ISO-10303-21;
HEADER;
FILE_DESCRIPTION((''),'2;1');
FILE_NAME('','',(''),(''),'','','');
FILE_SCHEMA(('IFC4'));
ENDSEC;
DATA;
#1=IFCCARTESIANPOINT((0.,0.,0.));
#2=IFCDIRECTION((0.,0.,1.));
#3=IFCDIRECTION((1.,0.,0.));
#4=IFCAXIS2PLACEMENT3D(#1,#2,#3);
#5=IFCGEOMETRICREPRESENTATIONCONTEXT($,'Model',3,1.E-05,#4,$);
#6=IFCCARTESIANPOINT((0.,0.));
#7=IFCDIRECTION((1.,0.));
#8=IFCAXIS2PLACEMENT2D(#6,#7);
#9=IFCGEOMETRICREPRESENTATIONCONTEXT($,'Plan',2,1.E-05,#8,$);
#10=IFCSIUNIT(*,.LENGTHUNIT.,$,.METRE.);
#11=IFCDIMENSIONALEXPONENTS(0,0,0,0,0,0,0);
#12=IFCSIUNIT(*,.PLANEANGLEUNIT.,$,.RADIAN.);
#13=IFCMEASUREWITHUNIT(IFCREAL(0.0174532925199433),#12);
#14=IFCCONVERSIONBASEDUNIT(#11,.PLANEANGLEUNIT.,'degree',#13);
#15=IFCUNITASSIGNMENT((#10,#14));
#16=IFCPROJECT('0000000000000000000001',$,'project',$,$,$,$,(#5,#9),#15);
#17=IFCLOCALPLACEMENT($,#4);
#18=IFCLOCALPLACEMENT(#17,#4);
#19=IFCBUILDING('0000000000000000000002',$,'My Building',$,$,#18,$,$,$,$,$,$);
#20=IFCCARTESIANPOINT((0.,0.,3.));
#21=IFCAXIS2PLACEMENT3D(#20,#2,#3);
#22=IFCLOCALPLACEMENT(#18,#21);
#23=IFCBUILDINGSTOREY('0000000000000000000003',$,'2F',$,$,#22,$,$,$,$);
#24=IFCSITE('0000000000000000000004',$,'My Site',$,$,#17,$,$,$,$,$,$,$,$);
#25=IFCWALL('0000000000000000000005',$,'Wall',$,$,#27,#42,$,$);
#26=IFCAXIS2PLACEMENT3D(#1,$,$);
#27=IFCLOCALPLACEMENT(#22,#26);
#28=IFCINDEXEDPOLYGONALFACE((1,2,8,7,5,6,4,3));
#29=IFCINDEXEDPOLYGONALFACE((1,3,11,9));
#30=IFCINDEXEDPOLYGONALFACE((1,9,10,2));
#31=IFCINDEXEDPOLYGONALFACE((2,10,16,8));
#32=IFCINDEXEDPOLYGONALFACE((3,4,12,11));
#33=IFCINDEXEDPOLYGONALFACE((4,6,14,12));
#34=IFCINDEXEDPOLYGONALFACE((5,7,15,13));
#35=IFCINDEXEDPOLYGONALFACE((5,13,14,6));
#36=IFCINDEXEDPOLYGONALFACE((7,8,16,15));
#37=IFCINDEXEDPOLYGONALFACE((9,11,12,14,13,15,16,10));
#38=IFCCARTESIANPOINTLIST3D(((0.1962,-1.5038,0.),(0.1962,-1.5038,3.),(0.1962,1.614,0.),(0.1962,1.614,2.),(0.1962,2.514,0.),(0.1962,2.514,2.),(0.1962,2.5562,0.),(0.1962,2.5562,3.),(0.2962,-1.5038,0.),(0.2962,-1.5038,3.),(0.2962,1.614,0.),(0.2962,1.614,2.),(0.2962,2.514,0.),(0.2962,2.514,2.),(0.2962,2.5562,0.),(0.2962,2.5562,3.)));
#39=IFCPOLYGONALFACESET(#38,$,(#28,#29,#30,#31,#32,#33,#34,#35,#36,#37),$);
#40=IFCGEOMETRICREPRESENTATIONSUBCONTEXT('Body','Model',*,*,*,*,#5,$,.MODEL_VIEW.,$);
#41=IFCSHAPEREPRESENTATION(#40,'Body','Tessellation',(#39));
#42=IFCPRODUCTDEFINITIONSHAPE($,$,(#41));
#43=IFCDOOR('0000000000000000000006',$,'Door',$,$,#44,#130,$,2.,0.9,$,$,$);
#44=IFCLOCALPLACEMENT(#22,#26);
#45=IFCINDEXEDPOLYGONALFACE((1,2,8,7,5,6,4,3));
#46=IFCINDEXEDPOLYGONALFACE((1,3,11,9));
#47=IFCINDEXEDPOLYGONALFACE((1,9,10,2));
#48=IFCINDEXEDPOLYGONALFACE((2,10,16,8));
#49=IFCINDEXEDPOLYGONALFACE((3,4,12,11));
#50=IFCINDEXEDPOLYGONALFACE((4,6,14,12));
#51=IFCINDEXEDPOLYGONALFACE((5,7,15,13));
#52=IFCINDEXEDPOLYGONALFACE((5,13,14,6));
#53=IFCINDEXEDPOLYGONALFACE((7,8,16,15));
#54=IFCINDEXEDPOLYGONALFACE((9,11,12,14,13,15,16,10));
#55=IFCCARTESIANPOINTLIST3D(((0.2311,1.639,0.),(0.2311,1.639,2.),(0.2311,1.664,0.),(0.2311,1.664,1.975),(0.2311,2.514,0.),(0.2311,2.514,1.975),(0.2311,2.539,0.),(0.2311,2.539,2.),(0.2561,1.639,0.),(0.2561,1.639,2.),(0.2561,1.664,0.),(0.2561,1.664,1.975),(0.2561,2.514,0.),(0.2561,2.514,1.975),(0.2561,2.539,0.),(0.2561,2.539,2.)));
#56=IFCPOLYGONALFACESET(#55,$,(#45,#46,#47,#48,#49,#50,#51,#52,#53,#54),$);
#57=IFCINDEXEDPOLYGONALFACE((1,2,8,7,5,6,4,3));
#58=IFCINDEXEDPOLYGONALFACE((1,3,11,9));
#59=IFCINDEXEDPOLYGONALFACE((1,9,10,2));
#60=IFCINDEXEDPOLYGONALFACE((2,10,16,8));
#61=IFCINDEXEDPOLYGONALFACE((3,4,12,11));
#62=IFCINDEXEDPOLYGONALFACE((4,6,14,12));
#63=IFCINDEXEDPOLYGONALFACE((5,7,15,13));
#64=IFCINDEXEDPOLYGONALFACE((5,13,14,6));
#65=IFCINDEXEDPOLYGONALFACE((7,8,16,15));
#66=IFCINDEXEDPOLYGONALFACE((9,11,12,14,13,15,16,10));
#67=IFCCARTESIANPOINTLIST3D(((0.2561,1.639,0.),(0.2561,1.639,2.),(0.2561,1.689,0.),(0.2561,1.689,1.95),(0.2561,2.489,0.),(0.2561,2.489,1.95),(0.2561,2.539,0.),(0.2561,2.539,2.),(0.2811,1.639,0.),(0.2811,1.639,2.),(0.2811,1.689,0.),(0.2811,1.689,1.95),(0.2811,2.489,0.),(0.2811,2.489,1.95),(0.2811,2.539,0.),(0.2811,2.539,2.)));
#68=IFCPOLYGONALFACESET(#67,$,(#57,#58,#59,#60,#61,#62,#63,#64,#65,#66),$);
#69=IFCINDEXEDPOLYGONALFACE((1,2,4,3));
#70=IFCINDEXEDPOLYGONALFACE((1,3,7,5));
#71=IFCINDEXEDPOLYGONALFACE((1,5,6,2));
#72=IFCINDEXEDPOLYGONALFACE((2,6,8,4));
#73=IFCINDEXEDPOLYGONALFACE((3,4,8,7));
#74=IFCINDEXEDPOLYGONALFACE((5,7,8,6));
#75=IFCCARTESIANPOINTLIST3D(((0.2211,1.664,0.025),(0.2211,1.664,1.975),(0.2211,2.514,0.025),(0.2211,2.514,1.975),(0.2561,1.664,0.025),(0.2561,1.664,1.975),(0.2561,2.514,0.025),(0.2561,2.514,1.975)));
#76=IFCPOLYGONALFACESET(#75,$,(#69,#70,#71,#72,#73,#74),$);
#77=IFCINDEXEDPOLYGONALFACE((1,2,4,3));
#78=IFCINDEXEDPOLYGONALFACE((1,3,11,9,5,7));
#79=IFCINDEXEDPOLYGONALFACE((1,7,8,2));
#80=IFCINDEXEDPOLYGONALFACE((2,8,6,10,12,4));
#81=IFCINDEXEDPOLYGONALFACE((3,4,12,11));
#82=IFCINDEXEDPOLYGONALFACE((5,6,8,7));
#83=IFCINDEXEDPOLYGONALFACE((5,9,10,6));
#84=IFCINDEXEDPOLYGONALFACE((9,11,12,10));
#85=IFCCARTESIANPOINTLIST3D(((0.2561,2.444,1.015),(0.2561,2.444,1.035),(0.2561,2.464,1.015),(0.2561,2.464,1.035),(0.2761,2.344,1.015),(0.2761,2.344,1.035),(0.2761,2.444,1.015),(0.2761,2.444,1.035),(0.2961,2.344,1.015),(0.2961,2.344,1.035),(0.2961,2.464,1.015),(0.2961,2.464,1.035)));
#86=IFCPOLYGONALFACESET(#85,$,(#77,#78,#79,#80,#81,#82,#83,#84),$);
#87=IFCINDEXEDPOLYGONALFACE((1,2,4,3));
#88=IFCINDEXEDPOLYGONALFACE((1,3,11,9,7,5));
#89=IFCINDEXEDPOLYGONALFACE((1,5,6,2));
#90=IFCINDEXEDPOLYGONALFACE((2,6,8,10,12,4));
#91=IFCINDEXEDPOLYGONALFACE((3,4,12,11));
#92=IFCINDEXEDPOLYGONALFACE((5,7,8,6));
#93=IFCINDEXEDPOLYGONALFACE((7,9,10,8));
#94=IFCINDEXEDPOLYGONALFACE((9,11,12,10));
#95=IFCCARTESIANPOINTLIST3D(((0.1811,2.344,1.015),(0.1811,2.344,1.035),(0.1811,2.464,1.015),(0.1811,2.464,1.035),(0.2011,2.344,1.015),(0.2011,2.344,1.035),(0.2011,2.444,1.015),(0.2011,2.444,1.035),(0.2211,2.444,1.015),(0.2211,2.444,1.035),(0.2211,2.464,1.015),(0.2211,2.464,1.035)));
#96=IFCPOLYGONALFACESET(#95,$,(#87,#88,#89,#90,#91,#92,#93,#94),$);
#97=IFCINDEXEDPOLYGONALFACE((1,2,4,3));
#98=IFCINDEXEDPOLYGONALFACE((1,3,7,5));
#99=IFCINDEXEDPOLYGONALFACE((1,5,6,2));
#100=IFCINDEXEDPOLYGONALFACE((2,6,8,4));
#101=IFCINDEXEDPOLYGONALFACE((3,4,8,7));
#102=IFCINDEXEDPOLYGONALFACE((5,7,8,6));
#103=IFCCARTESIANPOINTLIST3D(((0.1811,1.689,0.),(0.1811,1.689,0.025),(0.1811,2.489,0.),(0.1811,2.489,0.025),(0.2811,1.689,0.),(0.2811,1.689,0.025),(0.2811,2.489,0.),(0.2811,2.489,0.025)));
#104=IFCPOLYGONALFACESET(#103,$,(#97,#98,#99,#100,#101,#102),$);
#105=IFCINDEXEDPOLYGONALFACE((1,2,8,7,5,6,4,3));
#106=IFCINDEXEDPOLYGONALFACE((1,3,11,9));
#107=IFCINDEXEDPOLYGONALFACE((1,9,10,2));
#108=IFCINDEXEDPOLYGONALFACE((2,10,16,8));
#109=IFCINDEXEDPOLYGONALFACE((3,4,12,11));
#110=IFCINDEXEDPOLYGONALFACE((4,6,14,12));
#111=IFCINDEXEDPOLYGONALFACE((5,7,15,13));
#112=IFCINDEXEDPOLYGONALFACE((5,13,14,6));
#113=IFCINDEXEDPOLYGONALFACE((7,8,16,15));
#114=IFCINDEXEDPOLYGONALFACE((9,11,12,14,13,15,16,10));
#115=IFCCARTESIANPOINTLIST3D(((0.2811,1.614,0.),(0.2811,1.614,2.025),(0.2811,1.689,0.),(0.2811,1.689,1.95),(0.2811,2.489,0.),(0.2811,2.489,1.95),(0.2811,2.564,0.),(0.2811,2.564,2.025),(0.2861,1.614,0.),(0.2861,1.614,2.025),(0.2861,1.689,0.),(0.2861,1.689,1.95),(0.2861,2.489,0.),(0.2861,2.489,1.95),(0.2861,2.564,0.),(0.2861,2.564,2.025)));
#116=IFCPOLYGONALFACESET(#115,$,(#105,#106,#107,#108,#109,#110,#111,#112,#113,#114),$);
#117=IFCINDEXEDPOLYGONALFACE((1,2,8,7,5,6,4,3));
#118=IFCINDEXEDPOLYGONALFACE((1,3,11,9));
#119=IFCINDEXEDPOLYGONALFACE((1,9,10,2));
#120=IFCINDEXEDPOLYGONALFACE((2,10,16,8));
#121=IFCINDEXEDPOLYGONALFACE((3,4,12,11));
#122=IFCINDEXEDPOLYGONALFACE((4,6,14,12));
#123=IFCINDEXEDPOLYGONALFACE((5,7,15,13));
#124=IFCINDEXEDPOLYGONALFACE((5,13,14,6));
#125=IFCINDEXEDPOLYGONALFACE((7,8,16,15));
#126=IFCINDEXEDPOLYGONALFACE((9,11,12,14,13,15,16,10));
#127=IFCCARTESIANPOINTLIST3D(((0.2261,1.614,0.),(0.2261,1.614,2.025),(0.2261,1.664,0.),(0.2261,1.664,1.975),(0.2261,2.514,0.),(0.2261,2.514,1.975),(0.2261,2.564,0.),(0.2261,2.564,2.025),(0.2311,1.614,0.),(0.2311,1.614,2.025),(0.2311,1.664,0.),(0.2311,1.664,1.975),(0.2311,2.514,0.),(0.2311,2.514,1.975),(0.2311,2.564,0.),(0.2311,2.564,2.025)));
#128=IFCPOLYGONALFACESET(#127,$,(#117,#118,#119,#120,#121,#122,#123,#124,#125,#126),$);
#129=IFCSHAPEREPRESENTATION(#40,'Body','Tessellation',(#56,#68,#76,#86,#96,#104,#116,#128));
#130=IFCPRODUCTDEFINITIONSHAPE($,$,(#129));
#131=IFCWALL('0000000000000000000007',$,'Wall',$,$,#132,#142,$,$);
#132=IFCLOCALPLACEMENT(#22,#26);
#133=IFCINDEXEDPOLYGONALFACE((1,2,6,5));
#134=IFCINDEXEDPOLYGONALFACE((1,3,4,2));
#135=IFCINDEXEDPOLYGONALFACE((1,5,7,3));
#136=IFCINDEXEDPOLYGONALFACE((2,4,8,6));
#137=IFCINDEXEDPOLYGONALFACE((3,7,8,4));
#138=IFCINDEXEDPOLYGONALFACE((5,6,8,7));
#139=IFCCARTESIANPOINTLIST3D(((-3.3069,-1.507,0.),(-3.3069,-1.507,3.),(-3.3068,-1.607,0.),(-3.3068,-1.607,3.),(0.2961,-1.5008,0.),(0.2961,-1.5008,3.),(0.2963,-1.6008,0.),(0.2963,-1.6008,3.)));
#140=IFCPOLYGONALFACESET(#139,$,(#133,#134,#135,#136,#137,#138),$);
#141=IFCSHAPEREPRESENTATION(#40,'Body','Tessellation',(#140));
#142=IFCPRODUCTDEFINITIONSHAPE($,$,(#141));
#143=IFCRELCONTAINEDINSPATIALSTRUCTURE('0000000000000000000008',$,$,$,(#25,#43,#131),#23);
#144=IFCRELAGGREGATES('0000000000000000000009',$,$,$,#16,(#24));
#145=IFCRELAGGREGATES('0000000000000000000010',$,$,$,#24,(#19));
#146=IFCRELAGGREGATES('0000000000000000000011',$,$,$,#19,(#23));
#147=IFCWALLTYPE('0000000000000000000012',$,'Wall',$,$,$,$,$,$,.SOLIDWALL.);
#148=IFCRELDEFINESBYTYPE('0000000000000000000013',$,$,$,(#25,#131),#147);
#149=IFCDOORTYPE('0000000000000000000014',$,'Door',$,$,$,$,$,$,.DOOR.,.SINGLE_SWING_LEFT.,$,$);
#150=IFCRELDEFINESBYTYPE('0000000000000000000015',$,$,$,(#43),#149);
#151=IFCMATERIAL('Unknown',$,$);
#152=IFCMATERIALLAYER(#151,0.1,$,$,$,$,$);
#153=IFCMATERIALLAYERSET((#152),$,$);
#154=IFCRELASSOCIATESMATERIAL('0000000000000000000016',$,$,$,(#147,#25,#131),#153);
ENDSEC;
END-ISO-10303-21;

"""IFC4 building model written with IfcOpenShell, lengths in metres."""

from ifc_helpers import new_model, entity, si_unit, converted_unit, frame, origin_with_axes, origin_2d_with_axis, place, context, subcontext, project, spatial, line, indexed_curve, outline, extrude, shape, source, transform, mapped, material, layer, layer_set, layer_usage, type_object, type_shapes, element, fill, save


model = new_model("IFC4")

# Units and contexts
model_context = context("Model", 3, precision=1e-05, world=origin_with_axes())
plan_context = context("Plan", 2, precision=1e-05, world=origin_2d_with_axis())
body_context_1 = subcontext(model_context, "Body", "Model", "MODEL_VIEW")
body_context_2 = subcontext(plan_context, "Body", "Plan", "PLAN_VIEW")
ifc_project = project(units=[si_unit("LENGTHUNIT", "METRE"), converted_unit("PLANEANGLEUNIT", "degree", entity("IfcReal", 0.0174532925199433), si_unit("PLANEANGLEUNIT", "RADIAN"), dimensions=[0, 0, 0, 0, 0, 0, 0])], contexts=[model_context, plan_context])

# Site, building, storey
site_placement = place(None, origin_with_axes())
site = spatial("IfcSite", under=ifc_project, at=site_placement, Name="My Site")
building_placement = place(site_placement, origin_with_axes())
building = spatial("IfcBuilding", under=site, at=building_placement, Name="My Building")
storey_placement = place(building_placement, frame((0.0, 0.0, 3.0), z_axis=(0.0, 0.0, 1.0), x_axis=(1.0, 0.0, 0.0)))
storey = spatial("IfcBuildingStorey", under=building, at=storey_placement, Name="2F")

# Shared definitions
ifc_material = material(Name="Unknown")

# Shared definitions
ifc_layer_1 = layer(ifc_material, 0.1)
ifc_layer_set_1 = layer_set([ifc_layer_1])
wall_type = type_object("IfcWallType", Name="Wall", PredefinedType="SOLIDWALL", material=ifc_layer_set_1)

# Wall, opening, door
ifc_layer_usage_1 = layer_usage(ifc_layer_set_1, "AXIS2", "POSITIVE", 0.0)
wall_1_placement = place(storey_placement, frame((0.2962, -1.5038, 0.0), z_axis=(0.0, 0.0, 1.0), x_axis=(0.0, 1.0, 0.0)))
wall_1 = element("IfcWall", 1, at=wall_1_placement, inside=storey, type_object=wall_type, material=ifc_layer_usage_1, Name="Wall", context=body_context_1, shape_type="SweptSolid", body=[
    extrude(outline(indexed_curve([(0.0, 0.0), (0.0, 0.1), (4.06, 0.1), (4.06, 0.0)], segments=[line(1, 2, 3, 4, 1)])), origin_with_axes(), (0.0, 0.0, 1.0), 3.0),
])
shared_shape_1 = source(origin_with_axes(), body_context_1, "Body", "SweptSolid", [
    extrude(outline(indexed_curve([(0.0, 0.0), (0.9, 0.0), (0.9, 2.0), (0.0, 2.0)], segments=[line(1, 2, 3, 4, 1)])), frame((0.0, -0.6, 0.0), z_axis=(0.0, -1.0, 0.0), x_axis=(1.0, 0.0, 0.0)), (0.0, 0.0, -1.0), 1.2),
])
opening_1_placement = place(wall_1_placement, frame((3.1178, 0.0, 0.0), z_axis=(0.0, 0.0, 1.0), x_axis=(1.0, 0.0, 0.0)))
opening_1 = element("IfcOpeningElement", 2, at=opening_1_placement, cuts=wall_1, PredefinedType="OPENING", context=body_context_1, shape_type="MappedRepresentation", body=[
    mapped(shared_shape_1, transform((0.0, 0.0, 0.0), x_axis=(1.0, 0.0, 0.0), y_axis=(0.0, 1.0, 0.0), z_axis=(0.0, 0.0, 1.0), scale=1.0)),
])
door_type = type_object("IfcDoorType", Name="Door", OperationType="SINGLE_SWING_LEFT", PredefinedType="DOOR")
shared_shape_2 = source(origin_with_axes(), body_context_1, "Body", "SweptSolid", [
    extrude(outline(indexed_curve([(0.0, 0.0), (0.0, 2.0), (0.9, 2.0), (0.9, 0.0), (0.875, 0.0), (0.875, 1.975), (0.025, 1.975), (0.025, 0.0)], segments=[line(1, 2, 3, 4, 5, 6, 7, 8, 1)])), frame((0.0, 0.025, 0.0), z_axis=(0.0, -1.0, 0.0), x_axis=(1.0, 0.0, 0.0)), (0.0, 0.0, -1.0), 0.025),
    extrude(outline(indexed_curve([(0.0, 0.0), (0.0, 2.0), (0.9, 2.0), (0.9, 0.0), (0.85, 0.0), (0.85, 1.95), (0.05, 1.95), (0.05, 0.0)], segments=[line(1, 2, 3, 4, 5, 6, 7, 8, 1)])), frame((0.0, 0.0, 0.0), z_axis=(0.0, -1.0, 0.0), x_axis=(1.0, 0.0, 0.0)), (0.0, 0.0, -1.0), 0.025),
    extrude(outline(indexed_curve([(0.0, 0.0), (0.85, 0.0), (0.85, 0.035), (0.0, 0.035)], segments=[line(1, 2, 3, 4, 1)])), frame((0.025, 0.025, 0.025), z_axis=(0.0, 0.0, 1.0), x_axis=(1.0, 0.0, 0.0)), (0.0, 0.0, 1.0), 1.95),
    extrude(outline(indexed_curve([(0.0, 0.0), (0.0, -0.04), (-0.12, -0.04), (-0.12, -0.02), (-0.02, -0.02), (-0.02, 0.0)], segments=[line(1, 2, 3, 4, 5, 6, 1)])), frame((0.825, 0.025, 1.015), z_axis=(0.0, 0.0, 1.0), x_axis=(1.0, 0.0, 0.0)), (0.0, 0.0, 1.0), 0.02),
    extrude(outline(indexed_curve([(0.0, 0.0), (0.0, 0.04), (-0.12, 0.04), (-0.12, 0.02), (-0.02, 0.02), (-0.02, 0.0)], segments=[line(1, 2, 3, 4, 5, 6, 1)])), frame((0.825, 0.06, 1.015), z_axis=(0.0, 0.0, 1.0), x_axis=(1.0, 0.0, 0.0)), (0.0, 0.0, 1.0), 0.02),
    extrude(outline(indexed_curve([(0.0, 0.0), (0.8, 0.0), (0.8, 0.1), (0.0, 0.1)], segments=[line(1, 2, 3, 4, 1)])), frame((0.05, 0.0, 0.0), z_axis=(0.0, 0.0, 1.0), x_axis=(1.0, 0.0, 0.0)), (0.0, 0.0, 1.0), 0.025),
    extrude(outline(indexed_curve([(0.0, 0.0), (0.0, 2.025), (0.95, 2.025), (0.95, 0.0), (0.875, 0.0), (0.875, 1.95), (0.075, 1.95), (0.075, 0.0)], segments=[line(1, 2, 3, 4, 5, 6, 7, 8, 1)])), frame((-0.025, -0.005, 0.0), z_axis=(0.0, -1.0, 0.0), x_axis=(1.0, 0.0, 0.0)), (0.0, 0.0, -1.0), 0.005),
    extrude(outline(indexed_curve([(0.0, 0.0), (0.0, 2.025), (0.95, 2.025), (0.95, 0.0), (0.9, 0.0), (0.9, 1.975), (0.05, 1.975), (0.05, 0.0)], segments=[line(1, 2, 3, 4, 5, 6, 7, 8, 1)])), frame((-0.025, 0.05, 0.0), z_axis=(0.0, -1.0, 0.0), x_axis=(1.0, 0.0, 0.0)), (0.0, 0.0, -1.0), 0.005),
])
shared_shape_3 = source(origin_with_axes(), body_context_2, "Body", "Curve2D", [
    entity("IfcIndexedPolyCurve", entity("IfcCartesianPointList2D", [[0.0, 0.0], [0.0, 0.05], [0.025, 0.05], [0.025, 0.025], [0.05, 0.025], [0.05, 0.0]]), [entity("IfcLineIndex", [1, 2, 3, 4, 5, 6, 1])]),
    entity("IfcIndexedPolyCurve", entity("IfcCartesianPointList2D", [[0.9, 0.0], [0.9, 0.05], [0.875, 0.05], [0.875, 0.025], [0.85, 0.025], [0.85, 0.0]]), [entity("IfcLineIndex", [1, 2, 3, 4, 5, 6, 1])]),
    entity("IfcTrimmedCurve", entity("IfcEllipse", entity("IfcAxis2Placement2D", entity("IfcCartesianPoint", [0.06, 0.05]), entity("IfcDirection", [1.0, 0.0])), 0.815, 0.85), [entity("IfcCartesianPoint", [0.875, 0.05])], [entity("IfcCartesianPoint", [0.06, 0.9])], True, "CARTESIAN"),
    entity("IfcIndexedPolyCurve", entity("IfcCartesianPointList2D", [[0.025, 0.05], [0.06, 0.05], [0.06, 0.9], [0.025, 0.9]]), [entity("IfcLineIndex", [1, 2, 3, 4, 1])]),
])
type_shapes(door_type, [shared_shape_2, shared_shape_3])
door_1_placement = place(opening_1_placement, frame((0.025, 0.0151, 0.0), z_axis=(0.0, 0.0, 1.0), x_axis=(1.0, 0.0, 0.0)))
door_1 = element("IfcDoor", 3, at=door_1_placement, inside=storey, type_object=door_type, Name="Door", OverallHeight=2.0, OverallWidth=0.9, shapes=[
    shape(body_context_1, "Body", "MappedRepresentation", [mapped(shared_shape_2, transform((0.0, 0.0, 0.0), x_axis=(1.0, 0.0, 0.0), y_axis=(0.0, 1.0, 0.0), z_axis=(0.0, 0.0, 1.0), scale=1.0))]),
    shape(body_context_2, "Body", "MappedRepresentation", [mapped(shared_shape_3, transform((0.0, 0.0, 0.0), x_axis=(1.0, 0.0, 0.0), y_axis=(0.0, 1.0, 0.0), z_axis=(0.0, 0.0, 1.0), scale=1.0))]),
])
fill(opening_1, door_1)

# Wall
ifc_layer_usage_2 = layer_usage(ifc_layer_set_1, "AXIS2", "POSITIVE", 0.0)
wall_2_placement = place(storey_placement, frame((-3.3068, -1.607, 0.0), z_axis=(0.0, 0.0, 1.0), x_axis=(0.999999, 0.001712, 0.0)))
element("IfcWall", 4, at=wall_2_placement, inside=storey, type_object=wall_type, material=ifc_layer_usage_2, Name="Wall", context=body_context_1, shape_type="SweptSolid", body=[
    extrude(outline(indexed_curve([(0.0, 0.0), (0.0, 0.1), (3.6031, 0.1), (3.6031, 0.0)], segments=[line(1, 2, 3, 4, 1)])), origin_with_axes(), (0.0, 0.0, 1.0), 3.0),
])

save(model, "model.ifc")
